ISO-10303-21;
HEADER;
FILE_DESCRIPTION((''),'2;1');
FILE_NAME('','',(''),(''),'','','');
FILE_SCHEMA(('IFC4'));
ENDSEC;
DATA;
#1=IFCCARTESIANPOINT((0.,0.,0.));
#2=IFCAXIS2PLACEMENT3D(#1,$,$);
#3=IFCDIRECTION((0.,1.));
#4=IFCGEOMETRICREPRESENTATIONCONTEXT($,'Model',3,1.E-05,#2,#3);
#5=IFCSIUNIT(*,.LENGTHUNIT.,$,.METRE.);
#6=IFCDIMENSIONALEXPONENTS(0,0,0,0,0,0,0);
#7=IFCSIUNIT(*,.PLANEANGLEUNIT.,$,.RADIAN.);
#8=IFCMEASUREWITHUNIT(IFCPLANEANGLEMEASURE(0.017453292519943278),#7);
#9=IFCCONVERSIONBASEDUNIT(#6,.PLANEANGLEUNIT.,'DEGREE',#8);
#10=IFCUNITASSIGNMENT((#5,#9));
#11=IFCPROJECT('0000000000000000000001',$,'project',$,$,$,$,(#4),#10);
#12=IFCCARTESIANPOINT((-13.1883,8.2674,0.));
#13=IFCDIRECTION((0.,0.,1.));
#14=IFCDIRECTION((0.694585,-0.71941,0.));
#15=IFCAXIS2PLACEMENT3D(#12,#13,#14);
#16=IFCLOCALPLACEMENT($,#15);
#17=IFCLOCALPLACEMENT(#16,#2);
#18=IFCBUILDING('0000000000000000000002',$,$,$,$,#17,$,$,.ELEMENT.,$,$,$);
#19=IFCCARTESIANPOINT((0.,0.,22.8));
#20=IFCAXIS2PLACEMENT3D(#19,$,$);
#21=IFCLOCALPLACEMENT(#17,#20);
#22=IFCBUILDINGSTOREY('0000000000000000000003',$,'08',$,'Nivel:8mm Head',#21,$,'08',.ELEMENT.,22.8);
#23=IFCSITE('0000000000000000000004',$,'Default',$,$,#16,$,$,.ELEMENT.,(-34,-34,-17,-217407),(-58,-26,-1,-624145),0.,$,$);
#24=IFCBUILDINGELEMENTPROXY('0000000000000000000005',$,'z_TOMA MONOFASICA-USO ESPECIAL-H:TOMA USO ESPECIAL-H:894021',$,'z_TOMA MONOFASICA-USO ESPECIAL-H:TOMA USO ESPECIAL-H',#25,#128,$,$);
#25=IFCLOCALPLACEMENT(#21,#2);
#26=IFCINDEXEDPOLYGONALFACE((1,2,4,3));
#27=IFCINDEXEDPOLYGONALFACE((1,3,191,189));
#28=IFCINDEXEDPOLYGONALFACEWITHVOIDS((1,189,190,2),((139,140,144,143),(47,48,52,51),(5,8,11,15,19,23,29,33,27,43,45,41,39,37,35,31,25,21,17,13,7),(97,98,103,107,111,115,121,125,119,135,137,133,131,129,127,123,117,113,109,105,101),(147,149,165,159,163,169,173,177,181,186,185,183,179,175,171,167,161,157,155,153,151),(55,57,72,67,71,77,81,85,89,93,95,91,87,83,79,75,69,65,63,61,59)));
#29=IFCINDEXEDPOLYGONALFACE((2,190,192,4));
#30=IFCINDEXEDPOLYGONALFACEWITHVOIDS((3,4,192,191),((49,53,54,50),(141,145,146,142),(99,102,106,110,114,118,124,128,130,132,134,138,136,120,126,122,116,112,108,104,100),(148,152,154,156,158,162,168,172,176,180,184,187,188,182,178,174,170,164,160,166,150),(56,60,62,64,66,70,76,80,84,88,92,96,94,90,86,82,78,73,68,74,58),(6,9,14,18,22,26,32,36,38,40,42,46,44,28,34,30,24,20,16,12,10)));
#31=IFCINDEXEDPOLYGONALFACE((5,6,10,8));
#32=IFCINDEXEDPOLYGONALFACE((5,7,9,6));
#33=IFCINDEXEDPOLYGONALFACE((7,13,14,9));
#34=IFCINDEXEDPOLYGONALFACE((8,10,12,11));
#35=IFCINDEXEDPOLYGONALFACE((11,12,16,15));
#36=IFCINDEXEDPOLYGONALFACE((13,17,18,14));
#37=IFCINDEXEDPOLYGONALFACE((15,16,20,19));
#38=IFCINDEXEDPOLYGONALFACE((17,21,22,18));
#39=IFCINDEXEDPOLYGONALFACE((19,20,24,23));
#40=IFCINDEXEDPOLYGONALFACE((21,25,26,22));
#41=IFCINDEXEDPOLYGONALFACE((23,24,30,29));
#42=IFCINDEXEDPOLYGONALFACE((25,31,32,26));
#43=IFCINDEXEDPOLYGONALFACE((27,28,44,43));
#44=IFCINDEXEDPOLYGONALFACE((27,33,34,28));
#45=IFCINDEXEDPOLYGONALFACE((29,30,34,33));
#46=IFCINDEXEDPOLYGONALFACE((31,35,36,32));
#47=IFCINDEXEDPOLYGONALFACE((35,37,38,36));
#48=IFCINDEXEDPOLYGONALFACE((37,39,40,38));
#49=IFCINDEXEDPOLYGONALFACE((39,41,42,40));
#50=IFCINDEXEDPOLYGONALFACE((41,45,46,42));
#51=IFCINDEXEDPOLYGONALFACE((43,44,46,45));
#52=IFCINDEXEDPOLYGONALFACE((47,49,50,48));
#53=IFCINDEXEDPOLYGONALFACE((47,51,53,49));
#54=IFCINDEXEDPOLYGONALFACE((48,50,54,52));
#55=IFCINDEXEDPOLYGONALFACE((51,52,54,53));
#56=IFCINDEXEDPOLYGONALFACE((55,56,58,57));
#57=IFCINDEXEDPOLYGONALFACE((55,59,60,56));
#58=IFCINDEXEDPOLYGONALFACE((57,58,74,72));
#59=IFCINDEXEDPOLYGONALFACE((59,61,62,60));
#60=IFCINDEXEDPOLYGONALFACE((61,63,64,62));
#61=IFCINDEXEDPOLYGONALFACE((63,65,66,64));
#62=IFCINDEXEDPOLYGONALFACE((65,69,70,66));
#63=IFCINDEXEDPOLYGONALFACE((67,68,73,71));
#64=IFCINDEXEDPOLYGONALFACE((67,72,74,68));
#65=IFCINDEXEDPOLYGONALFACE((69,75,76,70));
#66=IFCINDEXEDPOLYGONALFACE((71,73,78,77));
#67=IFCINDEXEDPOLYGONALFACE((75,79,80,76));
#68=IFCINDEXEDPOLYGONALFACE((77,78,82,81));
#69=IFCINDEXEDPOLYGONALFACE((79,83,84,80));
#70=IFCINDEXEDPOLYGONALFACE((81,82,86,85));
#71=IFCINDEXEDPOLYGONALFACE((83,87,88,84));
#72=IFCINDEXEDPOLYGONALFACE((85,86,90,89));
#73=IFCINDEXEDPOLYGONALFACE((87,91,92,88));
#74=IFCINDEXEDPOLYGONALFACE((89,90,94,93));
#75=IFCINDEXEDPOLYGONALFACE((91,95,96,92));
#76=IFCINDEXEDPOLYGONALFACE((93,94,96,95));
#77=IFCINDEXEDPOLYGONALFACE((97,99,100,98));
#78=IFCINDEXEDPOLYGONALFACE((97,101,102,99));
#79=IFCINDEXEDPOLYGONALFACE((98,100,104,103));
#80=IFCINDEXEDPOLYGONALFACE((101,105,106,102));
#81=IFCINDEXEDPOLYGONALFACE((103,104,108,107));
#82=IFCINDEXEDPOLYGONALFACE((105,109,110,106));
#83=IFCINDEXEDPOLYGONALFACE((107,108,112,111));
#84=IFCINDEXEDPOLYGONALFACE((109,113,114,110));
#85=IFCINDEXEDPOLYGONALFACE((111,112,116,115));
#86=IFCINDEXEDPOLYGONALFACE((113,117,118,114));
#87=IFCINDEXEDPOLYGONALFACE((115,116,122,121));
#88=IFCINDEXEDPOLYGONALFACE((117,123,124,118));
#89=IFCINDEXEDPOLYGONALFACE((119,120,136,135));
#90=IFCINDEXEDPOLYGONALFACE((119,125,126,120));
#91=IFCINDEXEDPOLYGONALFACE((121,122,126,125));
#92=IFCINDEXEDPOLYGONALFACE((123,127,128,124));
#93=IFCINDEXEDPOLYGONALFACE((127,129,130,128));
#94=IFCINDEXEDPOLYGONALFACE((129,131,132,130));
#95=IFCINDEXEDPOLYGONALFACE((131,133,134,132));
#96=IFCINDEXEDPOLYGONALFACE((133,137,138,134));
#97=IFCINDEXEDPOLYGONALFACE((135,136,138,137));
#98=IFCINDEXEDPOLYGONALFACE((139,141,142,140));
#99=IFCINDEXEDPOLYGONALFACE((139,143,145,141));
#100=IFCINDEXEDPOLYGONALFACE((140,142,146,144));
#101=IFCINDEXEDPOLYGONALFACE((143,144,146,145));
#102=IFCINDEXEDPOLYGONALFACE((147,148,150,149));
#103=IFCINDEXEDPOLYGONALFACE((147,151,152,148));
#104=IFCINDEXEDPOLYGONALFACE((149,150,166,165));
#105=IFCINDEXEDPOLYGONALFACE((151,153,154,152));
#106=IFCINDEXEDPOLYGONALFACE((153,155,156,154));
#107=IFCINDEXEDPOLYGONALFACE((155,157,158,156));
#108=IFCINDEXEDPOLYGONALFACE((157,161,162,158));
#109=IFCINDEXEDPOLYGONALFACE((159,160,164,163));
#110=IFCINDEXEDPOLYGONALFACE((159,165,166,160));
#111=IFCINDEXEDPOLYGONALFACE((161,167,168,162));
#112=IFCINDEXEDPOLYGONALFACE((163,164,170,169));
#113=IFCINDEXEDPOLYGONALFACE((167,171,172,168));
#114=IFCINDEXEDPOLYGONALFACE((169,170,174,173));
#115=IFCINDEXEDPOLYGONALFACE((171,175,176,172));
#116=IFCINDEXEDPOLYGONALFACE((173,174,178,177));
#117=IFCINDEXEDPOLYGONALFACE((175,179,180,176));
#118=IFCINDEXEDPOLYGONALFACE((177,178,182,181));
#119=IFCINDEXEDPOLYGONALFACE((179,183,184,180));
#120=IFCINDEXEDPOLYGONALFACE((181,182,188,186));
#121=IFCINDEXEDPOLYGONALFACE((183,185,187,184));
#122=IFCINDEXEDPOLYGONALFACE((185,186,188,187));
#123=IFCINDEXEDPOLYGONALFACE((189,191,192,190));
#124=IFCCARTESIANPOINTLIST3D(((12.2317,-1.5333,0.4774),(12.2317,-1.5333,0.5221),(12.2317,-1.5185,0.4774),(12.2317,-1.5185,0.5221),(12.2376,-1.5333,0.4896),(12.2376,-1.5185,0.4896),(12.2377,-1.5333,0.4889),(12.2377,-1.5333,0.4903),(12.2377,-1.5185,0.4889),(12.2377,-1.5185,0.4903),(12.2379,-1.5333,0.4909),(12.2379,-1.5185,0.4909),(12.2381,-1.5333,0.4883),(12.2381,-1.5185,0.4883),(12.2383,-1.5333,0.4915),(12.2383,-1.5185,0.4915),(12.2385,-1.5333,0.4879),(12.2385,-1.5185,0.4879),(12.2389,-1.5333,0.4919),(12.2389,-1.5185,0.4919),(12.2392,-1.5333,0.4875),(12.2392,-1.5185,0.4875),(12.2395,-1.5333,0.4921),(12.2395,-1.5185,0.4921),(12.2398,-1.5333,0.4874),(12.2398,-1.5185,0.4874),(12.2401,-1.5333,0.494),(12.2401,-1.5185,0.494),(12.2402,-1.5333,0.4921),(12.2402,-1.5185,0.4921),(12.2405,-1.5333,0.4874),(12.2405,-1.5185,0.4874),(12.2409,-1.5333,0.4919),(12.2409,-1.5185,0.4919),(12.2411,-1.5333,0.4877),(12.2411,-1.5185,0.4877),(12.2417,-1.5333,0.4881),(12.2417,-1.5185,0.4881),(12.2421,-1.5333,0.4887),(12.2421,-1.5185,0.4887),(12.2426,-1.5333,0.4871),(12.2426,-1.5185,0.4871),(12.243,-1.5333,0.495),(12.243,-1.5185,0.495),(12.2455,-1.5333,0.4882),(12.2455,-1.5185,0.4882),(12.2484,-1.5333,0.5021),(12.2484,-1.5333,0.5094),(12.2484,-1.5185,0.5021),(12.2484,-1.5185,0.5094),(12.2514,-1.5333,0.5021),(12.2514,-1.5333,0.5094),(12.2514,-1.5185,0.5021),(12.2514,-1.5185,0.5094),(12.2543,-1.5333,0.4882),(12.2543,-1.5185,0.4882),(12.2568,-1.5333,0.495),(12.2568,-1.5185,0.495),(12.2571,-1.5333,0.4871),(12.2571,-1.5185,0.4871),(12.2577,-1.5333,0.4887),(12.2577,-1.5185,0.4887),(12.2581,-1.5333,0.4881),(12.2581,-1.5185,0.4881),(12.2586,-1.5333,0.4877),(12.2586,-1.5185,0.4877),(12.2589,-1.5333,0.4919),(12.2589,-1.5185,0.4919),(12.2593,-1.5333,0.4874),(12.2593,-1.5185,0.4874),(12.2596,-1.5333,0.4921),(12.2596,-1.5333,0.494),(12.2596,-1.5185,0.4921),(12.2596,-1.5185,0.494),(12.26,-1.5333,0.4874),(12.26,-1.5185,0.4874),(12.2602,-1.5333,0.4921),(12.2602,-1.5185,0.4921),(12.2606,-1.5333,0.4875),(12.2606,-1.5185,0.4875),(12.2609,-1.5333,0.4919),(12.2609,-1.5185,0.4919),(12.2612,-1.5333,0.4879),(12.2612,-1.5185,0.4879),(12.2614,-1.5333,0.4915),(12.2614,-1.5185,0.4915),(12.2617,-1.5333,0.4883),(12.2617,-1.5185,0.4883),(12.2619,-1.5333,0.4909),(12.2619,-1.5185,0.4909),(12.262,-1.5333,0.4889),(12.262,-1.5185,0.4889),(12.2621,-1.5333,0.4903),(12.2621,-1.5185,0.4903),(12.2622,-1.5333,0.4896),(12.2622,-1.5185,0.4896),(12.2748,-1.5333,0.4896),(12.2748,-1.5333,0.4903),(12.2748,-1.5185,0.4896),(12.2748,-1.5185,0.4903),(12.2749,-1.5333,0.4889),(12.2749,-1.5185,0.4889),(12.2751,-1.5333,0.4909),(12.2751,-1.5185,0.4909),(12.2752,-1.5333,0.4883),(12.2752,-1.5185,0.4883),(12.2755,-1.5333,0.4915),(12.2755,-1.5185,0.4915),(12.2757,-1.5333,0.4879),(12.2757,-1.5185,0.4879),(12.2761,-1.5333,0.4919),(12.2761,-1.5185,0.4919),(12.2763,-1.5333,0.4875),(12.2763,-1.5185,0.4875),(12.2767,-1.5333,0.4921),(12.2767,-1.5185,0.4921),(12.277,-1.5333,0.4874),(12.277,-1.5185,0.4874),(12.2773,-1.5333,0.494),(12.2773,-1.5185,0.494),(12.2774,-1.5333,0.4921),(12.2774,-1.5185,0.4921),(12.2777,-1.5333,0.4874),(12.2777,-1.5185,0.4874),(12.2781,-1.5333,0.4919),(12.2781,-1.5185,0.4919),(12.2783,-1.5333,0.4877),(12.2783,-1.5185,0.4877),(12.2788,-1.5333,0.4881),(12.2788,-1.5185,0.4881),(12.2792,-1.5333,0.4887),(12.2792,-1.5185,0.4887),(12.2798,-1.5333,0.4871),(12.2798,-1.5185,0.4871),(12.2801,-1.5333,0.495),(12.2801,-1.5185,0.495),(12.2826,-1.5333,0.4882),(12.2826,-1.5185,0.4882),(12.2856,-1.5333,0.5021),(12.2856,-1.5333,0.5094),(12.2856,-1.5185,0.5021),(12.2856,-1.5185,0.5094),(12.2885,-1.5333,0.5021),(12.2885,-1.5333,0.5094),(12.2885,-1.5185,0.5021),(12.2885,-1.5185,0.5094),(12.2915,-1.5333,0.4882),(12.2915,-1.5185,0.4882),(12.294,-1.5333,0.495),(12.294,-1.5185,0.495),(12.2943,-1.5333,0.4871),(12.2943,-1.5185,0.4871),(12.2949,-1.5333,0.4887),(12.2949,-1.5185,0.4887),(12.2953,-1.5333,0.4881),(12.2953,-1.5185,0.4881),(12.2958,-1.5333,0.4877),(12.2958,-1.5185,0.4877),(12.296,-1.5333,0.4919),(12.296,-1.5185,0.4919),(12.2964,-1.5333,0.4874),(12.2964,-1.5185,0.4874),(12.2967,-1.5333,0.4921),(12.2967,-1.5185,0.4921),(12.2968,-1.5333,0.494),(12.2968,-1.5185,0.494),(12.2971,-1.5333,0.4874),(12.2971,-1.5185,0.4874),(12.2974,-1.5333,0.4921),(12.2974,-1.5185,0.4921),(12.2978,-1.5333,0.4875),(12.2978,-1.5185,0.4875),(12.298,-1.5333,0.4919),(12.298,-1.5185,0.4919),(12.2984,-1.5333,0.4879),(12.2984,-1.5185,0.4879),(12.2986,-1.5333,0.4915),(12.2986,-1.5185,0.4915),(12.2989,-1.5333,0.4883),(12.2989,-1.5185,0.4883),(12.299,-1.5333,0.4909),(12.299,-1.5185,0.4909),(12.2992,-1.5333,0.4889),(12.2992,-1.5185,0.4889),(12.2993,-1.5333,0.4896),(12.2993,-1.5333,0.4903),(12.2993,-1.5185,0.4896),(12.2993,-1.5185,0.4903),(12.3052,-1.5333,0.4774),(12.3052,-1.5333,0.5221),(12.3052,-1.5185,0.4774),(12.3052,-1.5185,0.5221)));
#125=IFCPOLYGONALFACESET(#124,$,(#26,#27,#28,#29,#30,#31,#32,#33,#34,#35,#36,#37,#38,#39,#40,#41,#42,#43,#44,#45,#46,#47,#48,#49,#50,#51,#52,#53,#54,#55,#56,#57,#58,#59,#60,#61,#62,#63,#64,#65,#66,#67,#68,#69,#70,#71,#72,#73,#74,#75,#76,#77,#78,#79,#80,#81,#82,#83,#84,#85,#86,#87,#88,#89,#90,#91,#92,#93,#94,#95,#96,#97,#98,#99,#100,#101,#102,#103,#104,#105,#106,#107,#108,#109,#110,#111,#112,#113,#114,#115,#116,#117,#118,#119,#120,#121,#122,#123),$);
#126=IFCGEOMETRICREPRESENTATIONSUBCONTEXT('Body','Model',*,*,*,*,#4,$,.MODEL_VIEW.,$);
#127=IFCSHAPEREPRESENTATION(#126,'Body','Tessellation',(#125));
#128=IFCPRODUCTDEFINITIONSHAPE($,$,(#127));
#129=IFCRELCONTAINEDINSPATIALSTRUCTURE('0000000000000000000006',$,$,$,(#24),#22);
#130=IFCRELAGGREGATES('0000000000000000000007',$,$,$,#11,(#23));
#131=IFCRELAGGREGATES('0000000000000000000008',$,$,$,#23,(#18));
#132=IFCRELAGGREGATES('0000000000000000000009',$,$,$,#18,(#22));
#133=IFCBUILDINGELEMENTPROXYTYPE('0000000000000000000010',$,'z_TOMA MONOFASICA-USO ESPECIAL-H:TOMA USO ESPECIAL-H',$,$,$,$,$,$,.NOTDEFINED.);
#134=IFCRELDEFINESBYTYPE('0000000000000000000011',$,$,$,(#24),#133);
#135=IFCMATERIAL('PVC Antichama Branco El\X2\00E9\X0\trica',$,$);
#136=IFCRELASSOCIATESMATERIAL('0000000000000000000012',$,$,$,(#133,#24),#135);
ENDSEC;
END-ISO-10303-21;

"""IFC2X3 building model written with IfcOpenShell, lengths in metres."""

from ifc_helpers import new_model, entity, si_unit, converted_unit, direction, frame, frame_2d, origin, place, context, subcontext, project, spatial, polyline, circle_curve, parameter, trimmed, segment, composite_curve, outline, extrude, source, transform, mapped, material, type_object, type_shapes, element, save


model = new_model("IFC2X3")

# Units and contexts
model_context = context("Model", 3, precision=1e-05, world=origin(), true_north=direction((0.0, 1.0)))
body_context = subcontext(model_context, "Body", "Model", "MODEL_VIEW")
ifc_project = project(units=[si_unit("LENGTHUNIT", "METRE"), converted_unit("PLANEANGLEUNIT", "DEGREE", entity("IfcPlaneAngleMeasure", 0.017453292519943278), si_unit("PLANEANGLEUNIT", "RADIAN"), dimensions=[0, 0, 0, 0, 0, 0, 0])], contexts=[model_context])

# Site, building, storey
site_placement = place(None, frame((-13.1883, 8.2674, 0.0), z_axis=(0.0, 0.0, 1.0), x_axis=(0.694585, -0.71941, 0.0)))
site = spatial("IfcSite", under=ifc_project, at=site_placement, Name="Default", CompositionType="ELEMENT", RefLatitude=(-34, -34, -17, -217407), RefLongitude=(-58, -26, -1, -624145), RefElevation=0.0)
building_placement = place(site_placement, origin())
building = spatial("IfcBuilding", under=site, at=building_placement, CompositionType="ELEMENT")
storey_placement = place(building_placement, frame((0.0, 0.0, 22.8)))
storey = spatial("IfcBuildingStorey", under=building, at=storey_placement, Name="08", ObjectType="Nivel:8mm Head", LongName="08", CompositionType="ELEMENT", Elevation=22.8)

# Building element proxy
ifc_material_1 = material(Name="PVC Antichama Branco Elétrica")
building_element_proxy_type_1 = type_object("IfcBuildingElementProxyType", Name="z_TOMA MONOFASICA-USO ESPECIAL-H:TOMA USO ESPECIAL-H", PredefinedType="NOTDEFINED", material=ifc_material_1)
shared_shape_1 = source(origin(), body_context, "Body", "SweptSolid", [
    extrude(outline(polyline([(-0.0368, -0.0223), (0.0368, -0.0223), (0.0368, 0.0223), (-0.0368, 0.0223), (-0.0368, -0.0223)]), holes=[composite_curve([segment(polyline([(0.0141, 0.0115), (0.0116, 0.0047)]), True, "CONTINUOUS"), segment(polyline([(0.0116, 0.0047), (0.0088, 0.0057)]), True, "CONTINUOUS"), segment(polyline([(0.0088, 0.0057), (0.0096, 0.0078)]), True, "CONTINUOUS"), segment(trimmed(circle_curve(frame_2d((0.0087, 0.0099), x_axis=(1.0, 0.0)), 0.0024), [parameter(27.118901)], [parameter(292.881099)], True, "PARAMETER"), False, "CONTINUOUS"), segment(polyline([(0.0108, 0.011), (0.0113, 0.0126)]), True, "CONTINUOUS"), segment(polyline([(0.0113, 0.0126), (0.0141, 0.0115)]), True, "CONTINUOUS")], self_intersect=False), composite_curve([segment(polyline([(0.0255, 0.0047), (0.023, 0.0115)]), True, "CONTINUOUS"), segment(polyline([(0.023, 0.0115), (0.0258, 0.0126)]), True, "CONTINUOUS"), segment(polyline([(0.0258, 0.0126), (0.0264, 0.011)]), True, "CONTINUOUS"), segment(trimmed(circle_curve(frame_2d((0.0285, 0.0099), x_axis=(1.0, 0.0)), 0.0024), [parameter(247.118901)], [parameter(152.881099)], True, "PARAMETER"), False, "CONTINUOUS"), segment(polyline([(0.0276, 0.0078), (0.0283, 0.0057)]), True, "CONTINUOUS"), segment(polyline([(0.0283, 0.0057), (0.0255, 0.0047)]), True, "CONTINUOUS")], self_intersect=False), polyline([(0.0201, -0.0024), (0.0201, -0.0097), (0.0171, -0.0097), (0.0171, -0.0024), (0.0201, -0.0024)]), composite_curve([segment(polyline([(-0.0141, 0.0115), (-0.0113, 0.0126)]), True, "CONTINUOUS"), segment(polyline([(-0.0113, 0.0126), (-0.0108, 0.011)]), True, "CONTINUOUS"), segment(trimmed(circle_curve(frame_2d((-0.0087, 0.0099), x_axis=(1.0, 0.0)), 0.0024), [parameter(247.118901)], [parameter(152.881099)], True, "PARAMETER"), False, "CONTINUOUS"), segment(polyline([(-0.0096, 0.0078), (-0.0088, 0.0057)]), True, "CONTINUOUS"), segment(polyline([(-0.0088, 0.0057), (-0.0116, 0.0047)]), True, "CONTINUOUS"), segment(polyline([(-0.0116, 0.0047), (-0.0141, 0.0115)]), True, "CONTINUOUS")], self_intersect=False), composite_curve([segment(polyline([(-0.0255, 0.0047), (-0.0283, 0.0057)]), True, "CONTINUOUS"), segment(polyline([(-0.0283, 0.0057), (-0.0276, 0.0078)]), True, "CONTINUOUS"), segment(trimmed(circle_curve(frame_2d((-0.0285, 0.0099), x_axis=(1.0, 0.0)), 0.0024), [parameter(27.118901)], [parameter(292.881099)], True, "PARAMETER"), False, "CONTINUOUS"), segment(polyline([(-0.0264, 0.011), (-0.0258, 0.0126)]), True, "CONTINUOUS"), segment(polyline([(-0.0258, 0.0126), (-0.023, 0.0115)]), True, "CONTINUOUS"), segment(polyline([(-0.023, 0.0115), (-0.0255, 0.0047)]), True, "CONTINUOUS")], self_intersect=False), polyline([(-0.0201, -0.0024), (-0.0171, -0.0024), (-0.0171, -0.0097), (-0.0201, -0.0097), (-0.0201, -0.0024)])]), frame((0.0, -0.005, 0.0223), z_axis=(0.0, 1.0, 0.0), x_axis=(1.0, 0.0, 0.0)), (0.0, 0.0, 1.0), 0.0148),
])
type_shapes(building_element_proxy_type_1, [shared_shape_1])
proxy_1_placement = place(storey_placement, frame((12.2685, -1.5283, 0.4774)))
element("IfcBuildingElementProxy", 1, at=proxy_1_placement, inside=storey, type_object=building_element_proxy_type_1, material=ifc_material_1, Name="z_TOMA MONOFASICA-USO ESPECIAL-H:TOMA USO ESPECIAL-H:894021", ObjectType="z_TOMA MONOFASICA-USO ESPECIAL-H:TOMA USO ESPECIAL-H", context=body_context, shape_type="MappedRepresentation", body=[
    mapped(shared_shape_1, transform((0.0, 0.0, 0.0), scale=1.0)),
])

save(model, "model.ifc")
